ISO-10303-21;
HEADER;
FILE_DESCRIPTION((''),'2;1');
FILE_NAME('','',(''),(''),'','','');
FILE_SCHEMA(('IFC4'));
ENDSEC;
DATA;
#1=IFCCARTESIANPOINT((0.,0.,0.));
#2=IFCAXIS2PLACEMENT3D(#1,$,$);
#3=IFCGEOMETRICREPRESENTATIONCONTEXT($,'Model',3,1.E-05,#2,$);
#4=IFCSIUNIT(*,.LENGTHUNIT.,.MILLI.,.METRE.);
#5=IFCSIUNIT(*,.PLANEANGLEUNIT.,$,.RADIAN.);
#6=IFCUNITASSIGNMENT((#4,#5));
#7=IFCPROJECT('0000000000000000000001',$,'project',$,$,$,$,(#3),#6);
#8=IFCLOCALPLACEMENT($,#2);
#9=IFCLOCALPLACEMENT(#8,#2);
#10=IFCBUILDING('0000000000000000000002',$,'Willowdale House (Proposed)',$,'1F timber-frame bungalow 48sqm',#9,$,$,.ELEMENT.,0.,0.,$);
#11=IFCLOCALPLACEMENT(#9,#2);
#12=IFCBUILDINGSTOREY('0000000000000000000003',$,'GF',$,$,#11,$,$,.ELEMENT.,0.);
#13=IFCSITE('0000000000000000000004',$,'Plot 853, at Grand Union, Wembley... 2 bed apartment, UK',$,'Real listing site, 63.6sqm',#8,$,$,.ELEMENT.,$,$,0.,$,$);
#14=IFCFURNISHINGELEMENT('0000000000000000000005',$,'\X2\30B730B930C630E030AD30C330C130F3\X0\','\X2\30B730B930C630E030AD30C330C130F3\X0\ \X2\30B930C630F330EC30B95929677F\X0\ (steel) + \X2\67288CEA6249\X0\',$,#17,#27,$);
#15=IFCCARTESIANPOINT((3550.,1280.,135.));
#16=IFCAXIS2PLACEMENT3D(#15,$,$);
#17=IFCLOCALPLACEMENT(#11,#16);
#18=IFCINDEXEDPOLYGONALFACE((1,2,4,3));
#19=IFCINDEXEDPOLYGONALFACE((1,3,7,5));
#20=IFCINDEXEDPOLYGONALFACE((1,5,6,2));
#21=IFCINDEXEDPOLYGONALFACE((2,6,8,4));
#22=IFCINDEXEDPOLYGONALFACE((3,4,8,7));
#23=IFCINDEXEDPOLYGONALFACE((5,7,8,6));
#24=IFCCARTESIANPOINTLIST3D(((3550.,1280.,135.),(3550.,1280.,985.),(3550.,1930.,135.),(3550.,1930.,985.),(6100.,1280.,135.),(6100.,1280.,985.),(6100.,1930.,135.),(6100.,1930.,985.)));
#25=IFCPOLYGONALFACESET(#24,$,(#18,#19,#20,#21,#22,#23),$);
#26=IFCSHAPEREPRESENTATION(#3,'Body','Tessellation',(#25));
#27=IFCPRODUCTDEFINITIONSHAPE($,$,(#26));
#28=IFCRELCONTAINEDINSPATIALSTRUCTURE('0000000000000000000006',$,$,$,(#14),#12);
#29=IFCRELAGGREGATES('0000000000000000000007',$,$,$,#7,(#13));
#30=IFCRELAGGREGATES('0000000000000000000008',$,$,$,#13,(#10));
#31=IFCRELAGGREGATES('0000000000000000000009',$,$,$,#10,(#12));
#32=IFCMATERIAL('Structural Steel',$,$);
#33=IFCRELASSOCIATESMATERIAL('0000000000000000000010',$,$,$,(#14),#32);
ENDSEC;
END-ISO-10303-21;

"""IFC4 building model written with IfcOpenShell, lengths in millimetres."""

from ifc_helpers import new_model, si_unit, frame, frame_2d, origin, place, context, project, spatial, rectangle, extrude, material, element, save


model = new_model("IFC4")

# Units and contexts
model_context = context("Model", 3, precision=1e-05, world=origin())
ifc_project = project(units=[si_unit("LENGTHUNIT", "METRE", prefix="MILLI"), si_unit("PLANEANGLEUNIT", "RADIAN")], contexts=[model_context])

# Site, building, storey
site_placement = place(None, origin())
site = spatial("IfcSite", under=ifc_project, at=site_placement, Name="Plot 853, at Grand Union, Wembley... 2 bed apartment, UK", ObjectType="Real listing site, 63.6sqm", CompositionType="ELEMENT", RefElevation=0.0)
building_placement = place(site_placement, origin())
building = spatial("IfcBuilding", under=site, at=building_placement, Name="Willowdale House (Proposed)", ObjectType="1F timber-frame bungalow 48sqm", CompositionType="ELEMENT", ElevationOfRefHeight=0.0, ElevationOfTerrain=0.0)
storey_placement = place(building_placement, origin())
storey = spatial("IfcBuildingStorey", under=building, at=storey_placement, Name="GF", CompositionType="ELEMENT", Elevation=0.0)

# Furnishing element
ifc_material_1 = material(Name="Structural Steel")
furnishing_placement = place(storey_placement, frame((3550.0, 1280.0, 135.0)))
element("IfcFurnishingElement", 1, at=furnishing_placement, inside=storey, material=ifc_material_1, Name="システムキッチン", Description="システムキッチン ステンレス天板 (steel) + 木質扉", context=model_context, shape_type="SweptSolid", body=[
    extrude(rectangle(XDim=2550.0, YDim=650.0, at=frame_2d((1275.0, 325.0))), frame((3550.0, 1280.0, 135.0)), (0.0, 0.0, 1.0), 850.0),
])

save(model, "model.ifc")
